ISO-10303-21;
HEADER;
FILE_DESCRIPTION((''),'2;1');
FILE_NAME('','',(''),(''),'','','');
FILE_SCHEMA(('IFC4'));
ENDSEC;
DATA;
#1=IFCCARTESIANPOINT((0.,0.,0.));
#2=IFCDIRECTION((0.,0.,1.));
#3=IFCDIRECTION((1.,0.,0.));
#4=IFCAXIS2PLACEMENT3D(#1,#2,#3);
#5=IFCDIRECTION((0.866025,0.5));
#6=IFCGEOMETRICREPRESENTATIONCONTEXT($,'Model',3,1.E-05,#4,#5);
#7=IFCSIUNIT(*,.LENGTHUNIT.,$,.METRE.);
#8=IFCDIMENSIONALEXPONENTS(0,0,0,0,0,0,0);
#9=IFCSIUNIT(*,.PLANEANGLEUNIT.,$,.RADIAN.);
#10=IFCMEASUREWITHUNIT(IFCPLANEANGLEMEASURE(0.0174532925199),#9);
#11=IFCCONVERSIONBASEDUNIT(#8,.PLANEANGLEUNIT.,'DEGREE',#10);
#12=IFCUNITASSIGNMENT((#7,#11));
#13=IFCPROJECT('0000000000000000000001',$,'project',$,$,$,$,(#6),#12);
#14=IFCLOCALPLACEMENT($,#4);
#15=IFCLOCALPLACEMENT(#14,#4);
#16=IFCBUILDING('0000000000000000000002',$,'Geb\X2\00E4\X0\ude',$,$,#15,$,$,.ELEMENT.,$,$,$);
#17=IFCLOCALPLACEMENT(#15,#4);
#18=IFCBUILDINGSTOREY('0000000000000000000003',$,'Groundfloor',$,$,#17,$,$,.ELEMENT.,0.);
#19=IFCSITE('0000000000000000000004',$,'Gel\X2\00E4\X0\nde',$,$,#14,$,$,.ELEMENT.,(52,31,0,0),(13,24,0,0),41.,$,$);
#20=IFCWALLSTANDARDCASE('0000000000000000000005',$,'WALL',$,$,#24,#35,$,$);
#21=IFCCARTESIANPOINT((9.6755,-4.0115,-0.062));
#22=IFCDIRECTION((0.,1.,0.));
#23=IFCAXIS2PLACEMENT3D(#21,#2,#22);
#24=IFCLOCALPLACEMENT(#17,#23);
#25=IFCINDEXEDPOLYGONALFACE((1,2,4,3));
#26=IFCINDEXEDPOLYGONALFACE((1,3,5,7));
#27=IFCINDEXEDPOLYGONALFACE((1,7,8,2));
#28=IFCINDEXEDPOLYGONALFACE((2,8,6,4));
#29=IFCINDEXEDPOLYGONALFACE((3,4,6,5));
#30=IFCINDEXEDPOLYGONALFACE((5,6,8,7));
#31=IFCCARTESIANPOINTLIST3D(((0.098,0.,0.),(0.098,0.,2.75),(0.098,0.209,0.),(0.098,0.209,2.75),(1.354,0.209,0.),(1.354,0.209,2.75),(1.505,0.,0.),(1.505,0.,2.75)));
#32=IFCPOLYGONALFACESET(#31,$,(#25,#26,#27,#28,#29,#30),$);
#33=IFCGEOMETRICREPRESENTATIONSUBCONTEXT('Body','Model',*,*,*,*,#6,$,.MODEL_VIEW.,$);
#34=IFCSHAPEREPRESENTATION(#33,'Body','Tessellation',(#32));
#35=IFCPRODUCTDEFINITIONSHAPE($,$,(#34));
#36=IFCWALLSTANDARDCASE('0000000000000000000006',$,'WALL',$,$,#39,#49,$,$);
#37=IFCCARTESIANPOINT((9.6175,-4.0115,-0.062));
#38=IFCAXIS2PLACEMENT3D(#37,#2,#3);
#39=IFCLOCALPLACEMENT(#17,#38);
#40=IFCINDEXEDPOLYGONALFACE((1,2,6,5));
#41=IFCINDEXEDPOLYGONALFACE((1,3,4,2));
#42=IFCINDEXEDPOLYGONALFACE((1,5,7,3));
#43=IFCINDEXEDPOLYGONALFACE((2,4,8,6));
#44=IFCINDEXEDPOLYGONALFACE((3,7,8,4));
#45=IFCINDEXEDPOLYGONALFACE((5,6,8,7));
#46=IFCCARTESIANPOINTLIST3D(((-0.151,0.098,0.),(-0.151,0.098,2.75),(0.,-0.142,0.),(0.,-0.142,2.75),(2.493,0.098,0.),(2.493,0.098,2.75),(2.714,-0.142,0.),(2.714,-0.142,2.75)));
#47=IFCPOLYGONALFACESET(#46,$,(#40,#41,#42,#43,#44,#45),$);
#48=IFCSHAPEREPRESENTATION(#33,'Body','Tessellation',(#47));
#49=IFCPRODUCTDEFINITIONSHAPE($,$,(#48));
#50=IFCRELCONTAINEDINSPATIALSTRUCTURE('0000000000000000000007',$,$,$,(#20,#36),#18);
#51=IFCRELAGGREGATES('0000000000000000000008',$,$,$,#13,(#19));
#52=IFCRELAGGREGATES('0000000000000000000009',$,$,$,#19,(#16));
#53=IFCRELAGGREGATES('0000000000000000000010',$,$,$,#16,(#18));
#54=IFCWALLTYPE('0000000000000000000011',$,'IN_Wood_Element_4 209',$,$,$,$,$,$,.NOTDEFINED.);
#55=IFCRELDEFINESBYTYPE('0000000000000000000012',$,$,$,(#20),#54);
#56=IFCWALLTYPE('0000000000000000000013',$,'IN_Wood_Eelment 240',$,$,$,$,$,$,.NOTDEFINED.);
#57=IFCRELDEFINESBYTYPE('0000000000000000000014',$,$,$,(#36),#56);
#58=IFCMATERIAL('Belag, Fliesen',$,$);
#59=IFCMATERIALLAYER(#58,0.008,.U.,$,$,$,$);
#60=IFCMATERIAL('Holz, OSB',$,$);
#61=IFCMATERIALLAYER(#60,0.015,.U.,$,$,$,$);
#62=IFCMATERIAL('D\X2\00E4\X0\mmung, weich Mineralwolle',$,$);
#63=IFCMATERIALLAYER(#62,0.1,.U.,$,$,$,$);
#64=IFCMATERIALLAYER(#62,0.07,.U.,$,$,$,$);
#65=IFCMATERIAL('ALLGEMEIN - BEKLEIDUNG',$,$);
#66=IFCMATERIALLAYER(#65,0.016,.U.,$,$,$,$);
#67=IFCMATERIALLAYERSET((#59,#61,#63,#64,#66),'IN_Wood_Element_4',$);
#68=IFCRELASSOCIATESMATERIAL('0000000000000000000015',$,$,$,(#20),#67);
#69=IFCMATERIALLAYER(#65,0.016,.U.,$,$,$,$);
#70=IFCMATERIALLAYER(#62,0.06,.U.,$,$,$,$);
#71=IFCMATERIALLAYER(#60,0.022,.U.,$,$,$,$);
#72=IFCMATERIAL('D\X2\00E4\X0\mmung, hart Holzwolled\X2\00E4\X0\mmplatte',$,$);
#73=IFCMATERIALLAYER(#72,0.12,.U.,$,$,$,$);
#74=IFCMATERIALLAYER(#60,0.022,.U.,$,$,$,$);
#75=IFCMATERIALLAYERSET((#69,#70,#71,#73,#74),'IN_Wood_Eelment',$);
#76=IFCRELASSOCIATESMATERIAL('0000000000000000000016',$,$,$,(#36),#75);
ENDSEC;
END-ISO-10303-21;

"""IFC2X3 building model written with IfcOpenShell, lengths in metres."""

from ifc_helpers import new_model, entity, si_unit, converted_unit, direction, frame, origin_with_axes, place, context, subcontext, project, spatial, polyline, outline, extrude, material, layer, layer_set, layer_usage, type_object, element, save


model = new_model("IFC2X3")

# Units and contexts
model_context = context("Model", 3, precision=1e-05, world=origin_with_axes(), true_north=direction((0.866025, 0.5)))
body_context = subcontext(model_context, "Body", "Model", "MODEL_VIEW")
ifc_project = project(units=[si_unit("LENGTHUNIT", "METRE"), converted_unit("PLANEANGLEUNIT", "DEGREE", entity("IfcPlaneAngleMeasure", 0.0174532925199), si_unit("PLANEANGLEUNIT", "RADIAN"), dimensions=[0, 0, 0, 0, 0, 0, 0])], contexts=[model_context])

# Site, building, storey
site_placement = place(None, origin_with_axes())
site = spatial("IfcSite", under=ifc_project, at=site_placement, Name="Gelände", CompositionType="ELEMENT", RefLatitude=(52, 31, 0, 0), RefLongitude=(13, 24, 0, 0), RefElevation=41.0)
building_placement = place(site_placement, origin_with_axes())
building = spatial("IfcBuilding", under=site, at=building_placement, Name="Gebäude", CompositionType="ELEMENT")
storey_placement = place(building_placement, origin_with_axes())
storey = spatial("IfcBuildingStorey", under=building, at=storey_placement, Name="Groundfloor", CompositionType="ELEMENT", Elevation=0.0)

# Shared definitions
ifc_material_1 = material(Name="Dämmung, hart Holzwolledämmplatte")

# Wall
ifc_material_2 = material(Name="Belag, Fliesen")
ifc_layer_1 = layer(ifc_material_2, 0.008, ventilated="UNKNOWN")
ifc_material_3 = material(Name="Holz, OSB")
ifc_layer_2 = layer(ifc_material_3, 0.015, ventilated="UNKNOWN")
ifc_material_4 = material(Name="Dämmung, weich Mineralwolle")
ifc_layer_3 = layer(ifc_material_4, 0.1, ventilated="UNKNOWN")
ifc_layer_4 = layer(ifc_material_4, 0.07, ventilated="UNKNOWN")
ifc_material_5 = material(Name="ALLGEMEIN - BEKLEIDUNG")
ifc_layer_5 = layer(ifc_material_5, 0.016, ventilated="UNKNOWN")
ifc_layer_set_1 = layer_set([ifc_layer_1, ifc_layer_2, ifc_layer_3, ifc_layer_4, ifc_layer_5], Name="IN_Wood_Element_4")
ifc_layer_usage_1 = layer_usage(ifc_layer_set_1, "AXIS2", "NEGATIVE", 0.209)
wall_type_1 = type_object("IfcWallType", Name="IN_Wood_Element_4 209", PredefinedType="NOTDEFINED")
wall_1_placement = place(storey_placement, frame((9.6755, -4.0115, -0.062), z_axis=(0.0, 0.0, 1.0), x_axis=(0.0, 1.0, 0.0)))
element("IfcWallStandardCase", 1, at=wall_1_placement, inside=storey, type_object=wall_type_1, material=ifc_layer_usage_1, Name="WALL", context=body_context, shape_type="SweptSolid", body=[
    extrude(outline(polyline([(0.098, 0.0), (1.505, 0.0), (1.354, 0.209), (0.098, 0.209), (0.098, 0.0)])), origin_with_axes(), (0.0, 0.0, 1.0), 2.75),
])

# Wall
ifc_layer_6 = layer(ifc_material_5, 0.016, ventilated="UNKNOWN")
ifc_layer_7 = layer(ifc_material_4, 0.06, ventilated="UNKNOWN")
ifc_layer_8 = layer(ifc_material_3, 0.022, ventilated="UNKNOWN")
ifc_layer_9 = layer(ifc_material_1, 0.12, ventilated="UNKNOWN")
ifc_layer_10 = layer(ifc_material_3, 0.022, ventilated="UNKNOWN")
ifc_layer_set_2 = layer_set([ifc_layer_6, ifc_layer_7, ifc_layer_8, ifc_layer_9, ifc_layer_10], Name="IN_Wood_Eelment")
ifc_layer_usage_2 = layer_usage(ifc_layer_set_2, "AXIS2", "NEGATIVE", 0.098)
wall_type_2 = type_object("IfcWallType", Name="IN_Wood_Eelment 240", PredefinedType="NOTDEFINED")
wall_2_placement = place(storey_placement, frame((9.6175, -4.0115, -0.062), z_axis=(0.0, 0.0, 1.0), x_axis=(1.0, 0.0, 0.0)))
element("IfcWallStandardCase", 2, at=wall_2_placement, inside=storey, type_object=wall_type_2, material=ifc_layer_usage_2, Name="WALL", context=body_context, shape_type="SweptSolid", body=[
    extrude(outline(polyline([(0.0, -0.142), (2.714, -0.142), (2.493, 0.098), (-0.151, 0.098), (0.0, -0.142)])), origin_with_axes(), (0.0, 0.0, 1.0), 2.75),
])

save(model, "model.ifc")
